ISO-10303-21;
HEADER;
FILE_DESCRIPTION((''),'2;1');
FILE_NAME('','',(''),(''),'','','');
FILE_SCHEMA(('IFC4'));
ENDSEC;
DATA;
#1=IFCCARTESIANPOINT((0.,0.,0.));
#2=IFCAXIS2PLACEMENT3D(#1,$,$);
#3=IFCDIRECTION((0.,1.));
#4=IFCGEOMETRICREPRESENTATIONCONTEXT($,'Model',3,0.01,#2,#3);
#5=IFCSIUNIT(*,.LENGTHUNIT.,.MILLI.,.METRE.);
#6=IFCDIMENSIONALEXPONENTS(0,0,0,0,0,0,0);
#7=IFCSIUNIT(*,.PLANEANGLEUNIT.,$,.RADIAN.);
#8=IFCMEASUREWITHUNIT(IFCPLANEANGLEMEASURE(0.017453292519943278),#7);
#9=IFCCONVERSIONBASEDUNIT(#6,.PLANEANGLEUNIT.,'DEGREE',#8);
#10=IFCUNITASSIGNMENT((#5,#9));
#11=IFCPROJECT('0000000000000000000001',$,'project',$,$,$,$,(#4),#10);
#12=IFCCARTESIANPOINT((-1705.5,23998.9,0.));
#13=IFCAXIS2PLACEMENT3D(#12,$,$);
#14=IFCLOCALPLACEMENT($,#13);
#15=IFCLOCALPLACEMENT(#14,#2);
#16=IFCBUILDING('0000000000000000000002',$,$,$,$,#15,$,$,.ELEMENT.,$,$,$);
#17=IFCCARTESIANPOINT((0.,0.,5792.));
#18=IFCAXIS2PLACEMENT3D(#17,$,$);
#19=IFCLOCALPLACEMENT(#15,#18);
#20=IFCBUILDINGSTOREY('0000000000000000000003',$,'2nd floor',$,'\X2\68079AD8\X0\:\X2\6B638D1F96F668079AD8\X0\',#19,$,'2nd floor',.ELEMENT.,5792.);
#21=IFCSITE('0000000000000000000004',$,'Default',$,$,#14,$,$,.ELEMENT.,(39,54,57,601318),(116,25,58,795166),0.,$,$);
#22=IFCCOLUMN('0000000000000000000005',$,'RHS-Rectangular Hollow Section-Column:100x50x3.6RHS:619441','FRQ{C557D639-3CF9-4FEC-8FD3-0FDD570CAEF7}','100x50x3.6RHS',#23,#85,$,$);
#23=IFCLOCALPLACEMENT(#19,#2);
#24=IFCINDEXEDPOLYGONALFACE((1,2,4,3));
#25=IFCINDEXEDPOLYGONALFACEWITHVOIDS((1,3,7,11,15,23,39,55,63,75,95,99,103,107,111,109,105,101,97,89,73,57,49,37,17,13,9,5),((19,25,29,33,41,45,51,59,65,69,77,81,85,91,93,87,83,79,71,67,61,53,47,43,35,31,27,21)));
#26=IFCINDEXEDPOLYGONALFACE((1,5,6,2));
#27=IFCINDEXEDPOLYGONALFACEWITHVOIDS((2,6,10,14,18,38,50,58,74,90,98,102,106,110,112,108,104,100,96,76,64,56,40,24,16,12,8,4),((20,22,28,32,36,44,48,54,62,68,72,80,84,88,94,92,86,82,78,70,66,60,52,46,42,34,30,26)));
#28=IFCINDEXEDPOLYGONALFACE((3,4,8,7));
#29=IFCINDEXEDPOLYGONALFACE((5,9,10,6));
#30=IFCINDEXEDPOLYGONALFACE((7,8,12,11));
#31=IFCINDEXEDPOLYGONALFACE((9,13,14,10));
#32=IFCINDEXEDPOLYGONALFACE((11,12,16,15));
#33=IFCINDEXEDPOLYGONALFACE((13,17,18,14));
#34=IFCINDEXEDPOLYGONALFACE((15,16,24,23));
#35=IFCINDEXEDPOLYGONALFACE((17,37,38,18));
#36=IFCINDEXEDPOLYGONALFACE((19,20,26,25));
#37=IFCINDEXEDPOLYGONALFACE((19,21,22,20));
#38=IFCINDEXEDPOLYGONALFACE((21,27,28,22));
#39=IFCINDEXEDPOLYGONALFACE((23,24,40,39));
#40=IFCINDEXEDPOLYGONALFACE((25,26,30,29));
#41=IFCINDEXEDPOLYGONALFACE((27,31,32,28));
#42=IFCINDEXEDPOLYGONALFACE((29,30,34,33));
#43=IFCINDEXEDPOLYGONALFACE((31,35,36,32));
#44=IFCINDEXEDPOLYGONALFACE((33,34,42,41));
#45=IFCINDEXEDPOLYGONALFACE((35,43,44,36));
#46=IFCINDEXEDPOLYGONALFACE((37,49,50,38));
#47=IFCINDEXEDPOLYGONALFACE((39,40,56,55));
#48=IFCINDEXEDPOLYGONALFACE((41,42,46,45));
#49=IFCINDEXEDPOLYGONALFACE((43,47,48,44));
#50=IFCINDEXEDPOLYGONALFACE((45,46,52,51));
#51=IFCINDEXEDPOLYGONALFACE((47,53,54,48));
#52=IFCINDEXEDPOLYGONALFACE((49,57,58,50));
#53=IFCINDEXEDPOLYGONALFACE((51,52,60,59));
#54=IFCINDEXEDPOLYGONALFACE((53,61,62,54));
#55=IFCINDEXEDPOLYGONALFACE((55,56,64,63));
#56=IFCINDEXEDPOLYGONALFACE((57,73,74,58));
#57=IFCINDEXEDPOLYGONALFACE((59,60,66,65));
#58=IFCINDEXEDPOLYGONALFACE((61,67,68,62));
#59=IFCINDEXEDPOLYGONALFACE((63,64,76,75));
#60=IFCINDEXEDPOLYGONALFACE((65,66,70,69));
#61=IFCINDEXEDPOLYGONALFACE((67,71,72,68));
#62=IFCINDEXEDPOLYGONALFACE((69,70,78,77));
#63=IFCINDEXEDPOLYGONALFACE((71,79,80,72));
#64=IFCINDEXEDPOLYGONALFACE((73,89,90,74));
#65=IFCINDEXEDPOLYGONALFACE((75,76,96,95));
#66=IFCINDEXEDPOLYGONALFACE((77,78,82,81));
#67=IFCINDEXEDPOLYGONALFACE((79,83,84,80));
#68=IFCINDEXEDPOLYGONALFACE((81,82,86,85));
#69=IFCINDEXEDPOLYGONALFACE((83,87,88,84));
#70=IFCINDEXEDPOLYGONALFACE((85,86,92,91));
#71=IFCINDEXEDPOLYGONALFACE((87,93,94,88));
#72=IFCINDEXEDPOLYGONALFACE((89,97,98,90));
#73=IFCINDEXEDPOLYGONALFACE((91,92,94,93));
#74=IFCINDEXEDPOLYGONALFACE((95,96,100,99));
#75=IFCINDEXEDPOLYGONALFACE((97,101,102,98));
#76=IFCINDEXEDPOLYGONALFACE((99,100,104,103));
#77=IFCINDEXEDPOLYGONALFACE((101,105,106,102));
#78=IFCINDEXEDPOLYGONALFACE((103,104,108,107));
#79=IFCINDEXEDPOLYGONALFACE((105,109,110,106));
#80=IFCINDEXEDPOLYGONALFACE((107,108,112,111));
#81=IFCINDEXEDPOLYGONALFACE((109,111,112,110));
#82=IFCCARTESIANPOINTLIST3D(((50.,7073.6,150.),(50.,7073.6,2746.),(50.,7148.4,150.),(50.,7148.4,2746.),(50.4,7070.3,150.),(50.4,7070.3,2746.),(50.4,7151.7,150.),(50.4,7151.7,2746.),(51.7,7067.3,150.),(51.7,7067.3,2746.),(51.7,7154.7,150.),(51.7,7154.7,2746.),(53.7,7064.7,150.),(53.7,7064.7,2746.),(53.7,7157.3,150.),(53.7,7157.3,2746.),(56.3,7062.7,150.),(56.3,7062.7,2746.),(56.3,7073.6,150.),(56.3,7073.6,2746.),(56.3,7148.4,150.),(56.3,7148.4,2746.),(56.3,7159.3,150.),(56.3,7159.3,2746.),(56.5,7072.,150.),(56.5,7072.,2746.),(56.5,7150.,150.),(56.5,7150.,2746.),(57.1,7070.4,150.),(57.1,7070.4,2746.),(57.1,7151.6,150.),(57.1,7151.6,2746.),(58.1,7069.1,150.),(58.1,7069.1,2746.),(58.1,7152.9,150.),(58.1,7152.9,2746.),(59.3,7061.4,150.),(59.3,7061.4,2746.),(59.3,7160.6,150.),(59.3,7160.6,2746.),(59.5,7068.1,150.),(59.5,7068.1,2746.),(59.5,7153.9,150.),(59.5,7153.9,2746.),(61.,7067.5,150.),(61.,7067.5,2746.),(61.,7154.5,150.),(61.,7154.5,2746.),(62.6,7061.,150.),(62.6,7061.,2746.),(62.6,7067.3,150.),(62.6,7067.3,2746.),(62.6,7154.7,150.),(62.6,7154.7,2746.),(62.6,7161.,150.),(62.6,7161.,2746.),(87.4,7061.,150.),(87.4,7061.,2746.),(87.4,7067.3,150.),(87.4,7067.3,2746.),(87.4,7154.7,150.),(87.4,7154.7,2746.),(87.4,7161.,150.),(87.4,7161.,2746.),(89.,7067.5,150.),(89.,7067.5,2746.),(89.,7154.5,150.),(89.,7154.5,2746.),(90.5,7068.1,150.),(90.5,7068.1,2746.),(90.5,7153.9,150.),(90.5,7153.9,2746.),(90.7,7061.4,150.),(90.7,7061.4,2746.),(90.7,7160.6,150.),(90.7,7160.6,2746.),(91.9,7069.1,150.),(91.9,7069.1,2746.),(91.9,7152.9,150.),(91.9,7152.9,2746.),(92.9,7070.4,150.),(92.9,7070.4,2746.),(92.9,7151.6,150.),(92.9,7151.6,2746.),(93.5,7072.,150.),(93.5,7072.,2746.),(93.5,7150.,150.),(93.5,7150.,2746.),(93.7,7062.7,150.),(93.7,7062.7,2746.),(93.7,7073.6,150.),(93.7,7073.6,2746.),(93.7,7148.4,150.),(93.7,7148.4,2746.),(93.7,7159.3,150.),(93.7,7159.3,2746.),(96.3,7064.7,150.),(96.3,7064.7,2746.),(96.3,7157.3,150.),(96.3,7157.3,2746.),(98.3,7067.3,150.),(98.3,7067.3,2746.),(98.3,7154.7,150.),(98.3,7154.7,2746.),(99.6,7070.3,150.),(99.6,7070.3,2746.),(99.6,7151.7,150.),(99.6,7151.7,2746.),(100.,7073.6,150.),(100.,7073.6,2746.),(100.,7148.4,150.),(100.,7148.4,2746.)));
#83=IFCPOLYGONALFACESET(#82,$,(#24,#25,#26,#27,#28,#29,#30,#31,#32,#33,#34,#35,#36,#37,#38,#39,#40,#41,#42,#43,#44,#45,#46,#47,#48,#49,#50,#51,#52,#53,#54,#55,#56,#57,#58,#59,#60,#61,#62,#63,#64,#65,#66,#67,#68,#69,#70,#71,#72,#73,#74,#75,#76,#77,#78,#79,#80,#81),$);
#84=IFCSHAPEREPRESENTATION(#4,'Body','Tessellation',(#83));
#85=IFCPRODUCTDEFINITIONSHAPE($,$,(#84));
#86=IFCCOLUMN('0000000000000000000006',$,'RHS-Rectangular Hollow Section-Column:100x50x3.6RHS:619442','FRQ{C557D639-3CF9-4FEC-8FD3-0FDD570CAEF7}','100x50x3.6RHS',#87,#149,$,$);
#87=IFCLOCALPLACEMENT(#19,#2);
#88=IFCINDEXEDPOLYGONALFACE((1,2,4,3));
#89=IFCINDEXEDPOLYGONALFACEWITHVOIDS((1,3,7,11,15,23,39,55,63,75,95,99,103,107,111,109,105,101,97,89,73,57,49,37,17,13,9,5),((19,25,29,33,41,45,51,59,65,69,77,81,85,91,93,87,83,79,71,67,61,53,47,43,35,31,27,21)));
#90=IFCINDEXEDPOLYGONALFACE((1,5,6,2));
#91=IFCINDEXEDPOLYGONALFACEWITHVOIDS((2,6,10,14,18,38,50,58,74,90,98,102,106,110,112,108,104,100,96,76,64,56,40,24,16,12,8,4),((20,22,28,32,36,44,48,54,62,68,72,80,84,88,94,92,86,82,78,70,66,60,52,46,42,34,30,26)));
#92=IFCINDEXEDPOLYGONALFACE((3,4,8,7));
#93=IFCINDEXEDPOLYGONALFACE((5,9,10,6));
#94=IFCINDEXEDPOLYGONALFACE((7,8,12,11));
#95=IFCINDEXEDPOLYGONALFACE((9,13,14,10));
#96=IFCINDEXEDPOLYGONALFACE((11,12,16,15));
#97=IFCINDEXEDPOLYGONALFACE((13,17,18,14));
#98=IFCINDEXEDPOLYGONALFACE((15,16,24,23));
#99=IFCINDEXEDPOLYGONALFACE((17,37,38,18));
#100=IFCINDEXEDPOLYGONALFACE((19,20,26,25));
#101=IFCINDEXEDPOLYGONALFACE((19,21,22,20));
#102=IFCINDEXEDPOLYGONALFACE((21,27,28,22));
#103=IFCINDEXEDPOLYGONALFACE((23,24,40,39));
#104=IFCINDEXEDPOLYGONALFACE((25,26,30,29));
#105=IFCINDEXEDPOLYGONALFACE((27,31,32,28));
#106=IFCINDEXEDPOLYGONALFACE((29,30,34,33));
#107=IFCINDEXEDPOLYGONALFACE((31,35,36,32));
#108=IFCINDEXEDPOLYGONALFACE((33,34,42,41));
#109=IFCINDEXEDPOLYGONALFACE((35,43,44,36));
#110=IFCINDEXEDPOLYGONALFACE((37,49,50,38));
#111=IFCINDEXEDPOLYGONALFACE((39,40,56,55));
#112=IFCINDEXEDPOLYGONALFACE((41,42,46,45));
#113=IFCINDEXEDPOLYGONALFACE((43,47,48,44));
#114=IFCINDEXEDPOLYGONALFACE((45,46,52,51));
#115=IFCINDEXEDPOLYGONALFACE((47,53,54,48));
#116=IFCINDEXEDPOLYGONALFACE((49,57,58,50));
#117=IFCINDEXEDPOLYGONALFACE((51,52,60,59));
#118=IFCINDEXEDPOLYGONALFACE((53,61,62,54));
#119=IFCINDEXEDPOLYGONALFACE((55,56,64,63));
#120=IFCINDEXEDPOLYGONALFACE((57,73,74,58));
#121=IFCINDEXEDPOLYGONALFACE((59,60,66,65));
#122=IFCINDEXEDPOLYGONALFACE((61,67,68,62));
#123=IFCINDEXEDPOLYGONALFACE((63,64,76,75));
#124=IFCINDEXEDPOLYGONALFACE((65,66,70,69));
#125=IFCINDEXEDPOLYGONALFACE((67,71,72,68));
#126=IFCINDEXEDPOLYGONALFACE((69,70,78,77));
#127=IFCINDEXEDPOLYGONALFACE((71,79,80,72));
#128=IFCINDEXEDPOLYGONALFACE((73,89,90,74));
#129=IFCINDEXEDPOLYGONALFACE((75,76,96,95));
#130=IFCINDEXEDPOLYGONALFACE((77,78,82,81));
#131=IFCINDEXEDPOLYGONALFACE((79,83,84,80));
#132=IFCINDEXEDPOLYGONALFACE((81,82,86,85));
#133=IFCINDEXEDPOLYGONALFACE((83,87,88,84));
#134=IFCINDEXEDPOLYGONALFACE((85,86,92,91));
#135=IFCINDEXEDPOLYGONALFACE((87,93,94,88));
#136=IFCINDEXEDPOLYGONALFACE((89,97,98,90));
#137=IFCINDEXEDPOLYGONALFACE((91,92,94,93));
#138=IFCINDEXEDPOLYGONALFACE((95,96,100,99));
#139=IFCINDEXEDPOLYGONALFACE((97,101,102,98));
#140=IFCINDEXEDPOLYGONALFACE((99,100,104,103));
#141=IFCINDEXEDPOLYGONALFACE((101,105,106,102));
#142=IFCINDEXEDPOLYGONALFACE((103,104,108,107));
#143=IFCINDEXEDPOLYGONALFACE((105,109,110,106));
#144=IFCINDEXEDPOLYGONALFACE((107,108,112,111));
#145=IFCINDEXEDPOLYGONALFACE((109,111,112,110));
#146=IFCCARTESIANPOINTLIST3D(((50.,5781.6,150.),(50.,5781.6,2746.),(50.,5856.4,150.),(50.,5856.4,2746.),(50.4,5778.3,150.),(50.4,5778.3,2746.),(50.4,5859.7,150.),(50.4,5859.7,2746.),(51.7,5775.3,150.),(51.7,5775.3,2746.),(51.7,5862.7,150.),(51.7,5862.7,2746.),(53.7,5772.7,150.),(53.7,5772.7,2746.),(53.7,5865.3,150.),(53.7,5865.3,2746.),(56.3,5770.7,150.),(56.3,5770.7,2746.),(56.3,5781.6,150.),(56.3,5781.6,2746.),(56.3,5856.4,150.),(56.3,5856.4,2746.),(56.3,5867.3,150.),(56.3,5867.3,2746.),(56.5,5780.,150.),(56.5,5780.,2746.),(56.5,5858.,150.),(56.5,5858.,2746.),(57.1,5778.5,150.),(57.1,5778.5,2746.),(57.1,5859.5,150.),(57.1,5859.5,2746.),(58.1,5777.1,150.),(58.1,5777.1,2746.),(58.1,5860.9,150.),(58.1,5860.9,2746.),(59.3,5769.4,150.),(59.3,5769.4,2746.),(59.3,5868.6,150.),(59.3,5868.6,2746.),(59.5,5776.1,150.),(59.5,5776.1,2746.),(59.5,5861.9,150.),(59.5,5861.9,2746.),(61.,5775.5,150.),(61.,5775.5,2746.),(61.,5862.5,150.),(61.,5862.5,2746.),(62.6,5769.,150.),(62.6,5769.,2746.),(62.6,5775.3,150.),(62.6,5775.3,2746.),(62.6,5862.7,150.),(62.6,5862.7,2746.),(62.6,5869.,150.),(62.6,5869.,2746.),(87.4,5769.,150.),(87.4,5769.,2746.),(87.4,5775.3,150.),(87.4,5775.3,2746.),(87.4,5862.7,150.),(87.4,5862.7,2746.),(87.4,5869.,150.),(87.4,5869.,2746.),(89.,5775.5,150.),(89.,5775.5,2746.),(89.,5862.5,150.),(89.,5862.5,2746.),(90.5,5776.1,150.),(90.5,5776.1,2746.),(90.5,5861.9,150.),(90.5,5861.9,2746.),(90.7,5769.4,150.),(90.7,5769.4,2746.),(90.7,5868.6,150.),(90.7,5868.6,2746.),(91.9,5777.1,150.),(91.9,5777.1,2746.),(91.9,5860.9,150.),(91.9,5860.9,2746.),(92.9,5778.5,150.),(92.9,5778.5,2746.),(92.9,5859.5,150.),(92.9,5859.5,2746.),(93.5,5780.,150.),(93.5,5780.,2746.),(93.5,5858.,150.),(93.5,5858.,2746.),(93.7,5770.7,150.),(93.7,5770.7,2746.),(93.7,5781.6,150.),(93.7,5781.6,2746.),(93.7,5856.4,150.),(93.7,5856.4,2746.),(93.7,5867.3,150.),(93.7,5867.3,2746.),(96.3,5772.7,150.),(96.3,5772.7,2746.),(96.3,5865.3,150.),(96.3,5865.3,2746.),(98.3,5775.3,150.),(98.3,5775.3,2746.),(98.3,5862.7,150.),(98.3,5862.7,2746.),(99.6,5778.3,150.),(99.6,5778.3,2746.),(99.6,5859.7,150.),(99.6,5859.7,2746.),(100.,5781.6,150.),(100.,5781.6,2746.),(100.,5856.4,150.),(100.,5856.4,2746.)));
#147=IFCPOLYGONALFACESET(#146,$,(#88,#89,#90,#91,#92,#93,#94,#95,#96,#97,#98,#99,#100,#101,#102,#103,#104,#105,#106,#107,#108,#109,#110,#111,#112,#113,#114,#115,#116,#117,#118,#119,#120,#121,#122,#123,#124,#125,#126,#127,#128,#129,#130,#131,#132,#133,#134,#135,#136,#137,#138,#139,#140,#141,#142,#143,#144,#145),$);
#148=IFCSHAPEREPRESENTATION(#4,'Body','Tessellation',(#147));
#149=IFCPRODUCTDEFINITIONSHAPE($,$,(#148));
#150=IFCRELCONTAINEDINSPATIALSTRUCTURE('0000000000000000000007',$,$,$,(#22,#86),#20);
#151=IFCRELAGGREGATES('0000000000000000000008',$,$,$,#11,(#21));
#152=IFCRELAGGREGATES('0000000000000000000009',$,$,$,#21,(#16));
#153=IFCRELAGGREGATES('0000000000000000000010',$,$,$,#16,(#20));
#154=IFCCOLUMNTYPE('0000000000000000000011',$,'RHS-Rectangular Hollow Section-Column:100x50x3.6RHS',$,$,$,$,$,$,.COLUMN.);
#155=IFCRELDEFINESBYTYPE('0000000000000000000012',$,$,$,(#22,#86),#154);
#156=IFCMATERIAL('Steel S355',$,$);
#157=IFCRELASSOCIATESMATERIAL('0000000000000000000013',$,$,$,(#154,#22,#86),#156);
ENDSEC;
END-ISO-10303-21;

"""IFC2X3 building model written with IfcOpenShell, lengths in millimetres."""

from ifc_helpers import new_model, entity, si_unit, converted_unit, point, direction, frame, frame_2d, origin, origin_2d, place, context, project, spatial, circle_curve, line_curve, trimmed, segment, composite_curve, hollow_rectangle, outline, extrude, clip, halfspace, material, type_object, element, save


model = new_model("IFC2X3")

# Units and contexts
model_context = context("Model", 3, precision=0.01, world=origin(), true_north=direction((0.0, 1.0)))
ifc_project = project(units=[si_unit("LENGTHUNIT", "METRE", prefix="MILLI"), converted_unit("PLANEANGLEUNIT", "DEGREE", entity("IfcPlaneAngleMeasure", 0.017453292519943278), si_unit("PLANEANGLEUNIT", "RADIAN"), dimensions=[0, 0, 0, 0, 0, 0, 0])], contexts=[model_context])

# Site, building, storey
site_placement = place(None, frame((-1705.5, 23998.9, 0.0)))
site = spatial("IfcSite", under=ifc_project, at=site_placement, Name="Default", CompositionType="ELEMENT", RefLatitude=(39, 54, 57, 601318), RefLongitude=(116, 25, 58, 795166), RefElevation=0.0)
building_placement = place(site_placement, origin())
building = spatial("IfcBuilding", under=site, at=building_placement, CompositionType="ELEMENT")
storey_placement = place(building_placement, frame((0.0, 0.0, 5792.0)))
storey = spatial("IfcBuildingStorey", under=building, at=storey_placement, Name="2nd floor", ObjectType="标高:正负零标高", LongName="2nd floor", CompositionType="ELEMENT", Elevation=5792.0)

# Shared definitions
ifc_material_1 = material(Name="Steel S355")
column_type = type_object("IfcColumnType", Name="RHS-Rectangular Hollow Section-Column:100x50x3.6RHS", PredefinedType="COLUMN", material=ifc_material_1)

# Columns, openings
column_1_placement = place(storey_placement, frame((75.0, 7111.0, 2876.9)))
column_1 = element("IfcColumn", 1, at=column_1_placement, inside=storey, type_object=column_type, material=ifc_material_1, Name="RHS-Rectangular Hollow Section-Column:100x50x3.6RHS:619441", Description="FRQ{C557D639-3CF9-4FEC-8FD3-0FDD570CAEF7}", ObjectType="100x50x3.6RHS", context=model_context, shape_type="Clipping", body=[
    clip(clip(extrude(hollow_rectangle(XDim=50.0, YDim=100.0, WallThickness=6.3, InnerFilletRadius=6.3, OuterFilletRadius=12.6, at=origin_2d()), origin(), (0.0, 0.0, -1.0), 2782.8), halfspace(frame((-75.0, -7111.0, -55.9), z_axis=(0.0, 0.0, -1.0), x_axis=(-1.0, 0.0, 0.0)), True)), halfspace(frame((-75.0, -7111.0, -2726.9), z_axis=(0.0, 0.0, 1.0), x_axis=(1.0, 0.0, 0.0)), True)),
])
opening_1_placement = place(column_1_placement, frame((0.0, -150.1, -130.9), z_axis=(0.0, 1.0, 0.0), x_axis=(-1.0, 0.0, 0.0)))
element("IfcOpeningElement", 2, at=opening_1_placement, cuts=column_1, ObjectType="Opening", context=model_context, shape_type="SweptSolid", body=[
    extrude(outline(composite_curve([segment(trimmed(circle_curve(frame_2d((43.0, 32.0), x_axis=(1.0, 0.0)), 32.0), [point((43.0, 0.0))], [point((75.0, 32.0))], True, "CARTESIAN"), True, "CONTINUOUS"), segment(trimmed(line_curve((75.0, 32.0), (0.0, 1.0), 86.0), [point((75.0, 32.0))], [point((75.0, 118.0))], True, "CARTESIAN"), True, "CONTINUOUS"), segment(trimmed(circle_curve(frame_2d((43.0, 118.0), x_axis=(1.0, 0.0)), 32.0), [point((75.0, 118.0))], [point((43.0, 150.0))], True, "CARTESIAN"), True, "CONTINUOUS"), segment(trimmed(line_curve((43.0, 150.0), (-1.0, 0.0), 86.0), [point((43.0, 150.0))], [point((-43.0, 150.0))], True, "CARTESIAN"), True, "CONTINUOUS"), segment(trimmed(circle_curve(frame_2d((-43.0, 118.0), x_axis=(1.0, 0.0)), 32.0), [point((-43.0, 150.0))], [point((-75.0, 118.0))], True, "CARTESIAN"), True, "CONTINUOUS"), segment(trimmed(line_curve((-75.0, 118.0), (0.0, -1.0), 86.0), [point((-75.0, 118.0))], [point((-75.0, 32.0))], True, "CARTESIAN"), True, "CONTINUOUS"), segment(trimmed(circle_curve(frame_2d((-43.0, 32.0), x_axis=(1.0, 0.0)), 32.0), [point((-75.0, 32.0))], [point((-43.0, 0.0))], True, "CARTESIAN"), True, "CONTINUOUS"), segment(trimmed(line_curve((-43.0, 0.0), (1.0, 0.0), 86.0), [point((-43.0, 0.0))], [point((43.0, 0.0))], True, "CARTESIAN"), True, "CONTINUOUS")], self_intersect="UNKNOWN")), origin(), (0.0, 0.0, 1.0), 300.2),
])
column_2_placement = place(storey_placement, frame((75.0, 5819.0, 2876.9)))
column_2 = element("IfcColumn", 3, at=column_2_placement, inside=storey, type_object=column_type, material=ifc_material_1, Name="RHS-Rectangular Hollow Section-Column:100x50x3.6RHS:619442", Description="FRQ{C557D639-3CF9-4FEC-8FD3-0FDD570CAEF7}", ObjectType="100x50x3.6RHS", context=model_context, shape_type="Clipping", body=[
    clip(clip(extrude(hollow_rectangle(XDim=50.0, YDim=100.0, WallThickness=6.3, InnerFilletRadius=6.3, OuterFilletRadius=12.6, at=origin_2d()), origin(), (0.0, 0.0, -1.0), 2782.8), halfspace(frame((-75.0, -5819.0, -2726.9), z_axis=(0.0, 0.0, 1.0), x_axis=(1.0, 0.0, 0.0)), True)), halfspace(frame((-75.0, -5819.0, -55.9), z_axis=(0.0, 0.0, -1.0), x_axis=(-1.0, 0.0, 0.0)), True)),
])
opening_2_placement = place(column_2_placement, frame((0.0, -150.1, -130.9), z_axis=(0.0, 1.0, 0.0), x_axis=(-1.0, 0.0, 0.0)))
element("IfcOpeningElement", 4, at=opening_2_placement, cuts=column_2, ObjectType="Opening", context=model_context, shape_type="SweptSolid", body=[
    extrude(outline(composite_curve([segment(trimmed(circle_curve(frame_2d((43.0, 32.0), x_axis=(1.0, 0.0)), 32.0), [point((43.0, 0.0))], [point((75.0, 32.0))], True, "CARTESIAN"), True, "CONTINUOUS"), segment(trimmed(line_curve((75.0, 32.0), (0.0, 1.0), 86.0), [point((75.0, 32.0))], [point((75.0, 118.0))], True, "CARTESIAN"), True, "CONTINUOUS"), segment(trimmed(circle_curve(frame_2d((43.0, 118.0), x_axis=(1.0, 0.0)), 32.0), [point((75.0, 118.0))], [point((43.0, 150.0))], True, "CARTESIAN"), True, "CONTINUOUS"), segment(trimmed(line_curve((43.0, 150.0), (-1.0, 0.0), 86.0), [point((43.0, 150.0))], [point((-43.0, 150.0))], True, "CARTESIAN"), True, "CONTINUOUS"), segment(trimmed(circle_curve(frame_2d((-43.0, 118.0), x_axis=(1.0, 0.0)), 32.0), [point((-43.0, 150.0))], [point((-75.0, 118.0))], True, "CARTESIAN"), True, "CONTINUOUS"), segment(trimmed(line_curve((-75.0, 118.0), (0.0, -1.0), 86.0), [point((-75.0, 118.0))], [point((-75.0, 32.0))], True, "CARTESIAN"), True, "CONTINUOUS"), segment(trimmed(circle_curve(frame_2d((-43.0, 32.0), x_axis=(1.0, 0.0)), 32.0), [point((-75.0, 32.0))], [point((-43.0, 0.0))], True, "CARTESIAN"), True, "CONTINUOUS"), segment(trimmed(line_curve((-43.0, 0.0), (1.0, 0.0), 86.0), [point((-43.0, 0.0))], [point((43.0, 0.0))], True, "CARTESIAN"), True, "CONTINUOUS")], self_intersect="UNKNOWN")), origin(), (0.0, 0.0, 1.0), 300.2),
])

save(model, "model.ifc")
